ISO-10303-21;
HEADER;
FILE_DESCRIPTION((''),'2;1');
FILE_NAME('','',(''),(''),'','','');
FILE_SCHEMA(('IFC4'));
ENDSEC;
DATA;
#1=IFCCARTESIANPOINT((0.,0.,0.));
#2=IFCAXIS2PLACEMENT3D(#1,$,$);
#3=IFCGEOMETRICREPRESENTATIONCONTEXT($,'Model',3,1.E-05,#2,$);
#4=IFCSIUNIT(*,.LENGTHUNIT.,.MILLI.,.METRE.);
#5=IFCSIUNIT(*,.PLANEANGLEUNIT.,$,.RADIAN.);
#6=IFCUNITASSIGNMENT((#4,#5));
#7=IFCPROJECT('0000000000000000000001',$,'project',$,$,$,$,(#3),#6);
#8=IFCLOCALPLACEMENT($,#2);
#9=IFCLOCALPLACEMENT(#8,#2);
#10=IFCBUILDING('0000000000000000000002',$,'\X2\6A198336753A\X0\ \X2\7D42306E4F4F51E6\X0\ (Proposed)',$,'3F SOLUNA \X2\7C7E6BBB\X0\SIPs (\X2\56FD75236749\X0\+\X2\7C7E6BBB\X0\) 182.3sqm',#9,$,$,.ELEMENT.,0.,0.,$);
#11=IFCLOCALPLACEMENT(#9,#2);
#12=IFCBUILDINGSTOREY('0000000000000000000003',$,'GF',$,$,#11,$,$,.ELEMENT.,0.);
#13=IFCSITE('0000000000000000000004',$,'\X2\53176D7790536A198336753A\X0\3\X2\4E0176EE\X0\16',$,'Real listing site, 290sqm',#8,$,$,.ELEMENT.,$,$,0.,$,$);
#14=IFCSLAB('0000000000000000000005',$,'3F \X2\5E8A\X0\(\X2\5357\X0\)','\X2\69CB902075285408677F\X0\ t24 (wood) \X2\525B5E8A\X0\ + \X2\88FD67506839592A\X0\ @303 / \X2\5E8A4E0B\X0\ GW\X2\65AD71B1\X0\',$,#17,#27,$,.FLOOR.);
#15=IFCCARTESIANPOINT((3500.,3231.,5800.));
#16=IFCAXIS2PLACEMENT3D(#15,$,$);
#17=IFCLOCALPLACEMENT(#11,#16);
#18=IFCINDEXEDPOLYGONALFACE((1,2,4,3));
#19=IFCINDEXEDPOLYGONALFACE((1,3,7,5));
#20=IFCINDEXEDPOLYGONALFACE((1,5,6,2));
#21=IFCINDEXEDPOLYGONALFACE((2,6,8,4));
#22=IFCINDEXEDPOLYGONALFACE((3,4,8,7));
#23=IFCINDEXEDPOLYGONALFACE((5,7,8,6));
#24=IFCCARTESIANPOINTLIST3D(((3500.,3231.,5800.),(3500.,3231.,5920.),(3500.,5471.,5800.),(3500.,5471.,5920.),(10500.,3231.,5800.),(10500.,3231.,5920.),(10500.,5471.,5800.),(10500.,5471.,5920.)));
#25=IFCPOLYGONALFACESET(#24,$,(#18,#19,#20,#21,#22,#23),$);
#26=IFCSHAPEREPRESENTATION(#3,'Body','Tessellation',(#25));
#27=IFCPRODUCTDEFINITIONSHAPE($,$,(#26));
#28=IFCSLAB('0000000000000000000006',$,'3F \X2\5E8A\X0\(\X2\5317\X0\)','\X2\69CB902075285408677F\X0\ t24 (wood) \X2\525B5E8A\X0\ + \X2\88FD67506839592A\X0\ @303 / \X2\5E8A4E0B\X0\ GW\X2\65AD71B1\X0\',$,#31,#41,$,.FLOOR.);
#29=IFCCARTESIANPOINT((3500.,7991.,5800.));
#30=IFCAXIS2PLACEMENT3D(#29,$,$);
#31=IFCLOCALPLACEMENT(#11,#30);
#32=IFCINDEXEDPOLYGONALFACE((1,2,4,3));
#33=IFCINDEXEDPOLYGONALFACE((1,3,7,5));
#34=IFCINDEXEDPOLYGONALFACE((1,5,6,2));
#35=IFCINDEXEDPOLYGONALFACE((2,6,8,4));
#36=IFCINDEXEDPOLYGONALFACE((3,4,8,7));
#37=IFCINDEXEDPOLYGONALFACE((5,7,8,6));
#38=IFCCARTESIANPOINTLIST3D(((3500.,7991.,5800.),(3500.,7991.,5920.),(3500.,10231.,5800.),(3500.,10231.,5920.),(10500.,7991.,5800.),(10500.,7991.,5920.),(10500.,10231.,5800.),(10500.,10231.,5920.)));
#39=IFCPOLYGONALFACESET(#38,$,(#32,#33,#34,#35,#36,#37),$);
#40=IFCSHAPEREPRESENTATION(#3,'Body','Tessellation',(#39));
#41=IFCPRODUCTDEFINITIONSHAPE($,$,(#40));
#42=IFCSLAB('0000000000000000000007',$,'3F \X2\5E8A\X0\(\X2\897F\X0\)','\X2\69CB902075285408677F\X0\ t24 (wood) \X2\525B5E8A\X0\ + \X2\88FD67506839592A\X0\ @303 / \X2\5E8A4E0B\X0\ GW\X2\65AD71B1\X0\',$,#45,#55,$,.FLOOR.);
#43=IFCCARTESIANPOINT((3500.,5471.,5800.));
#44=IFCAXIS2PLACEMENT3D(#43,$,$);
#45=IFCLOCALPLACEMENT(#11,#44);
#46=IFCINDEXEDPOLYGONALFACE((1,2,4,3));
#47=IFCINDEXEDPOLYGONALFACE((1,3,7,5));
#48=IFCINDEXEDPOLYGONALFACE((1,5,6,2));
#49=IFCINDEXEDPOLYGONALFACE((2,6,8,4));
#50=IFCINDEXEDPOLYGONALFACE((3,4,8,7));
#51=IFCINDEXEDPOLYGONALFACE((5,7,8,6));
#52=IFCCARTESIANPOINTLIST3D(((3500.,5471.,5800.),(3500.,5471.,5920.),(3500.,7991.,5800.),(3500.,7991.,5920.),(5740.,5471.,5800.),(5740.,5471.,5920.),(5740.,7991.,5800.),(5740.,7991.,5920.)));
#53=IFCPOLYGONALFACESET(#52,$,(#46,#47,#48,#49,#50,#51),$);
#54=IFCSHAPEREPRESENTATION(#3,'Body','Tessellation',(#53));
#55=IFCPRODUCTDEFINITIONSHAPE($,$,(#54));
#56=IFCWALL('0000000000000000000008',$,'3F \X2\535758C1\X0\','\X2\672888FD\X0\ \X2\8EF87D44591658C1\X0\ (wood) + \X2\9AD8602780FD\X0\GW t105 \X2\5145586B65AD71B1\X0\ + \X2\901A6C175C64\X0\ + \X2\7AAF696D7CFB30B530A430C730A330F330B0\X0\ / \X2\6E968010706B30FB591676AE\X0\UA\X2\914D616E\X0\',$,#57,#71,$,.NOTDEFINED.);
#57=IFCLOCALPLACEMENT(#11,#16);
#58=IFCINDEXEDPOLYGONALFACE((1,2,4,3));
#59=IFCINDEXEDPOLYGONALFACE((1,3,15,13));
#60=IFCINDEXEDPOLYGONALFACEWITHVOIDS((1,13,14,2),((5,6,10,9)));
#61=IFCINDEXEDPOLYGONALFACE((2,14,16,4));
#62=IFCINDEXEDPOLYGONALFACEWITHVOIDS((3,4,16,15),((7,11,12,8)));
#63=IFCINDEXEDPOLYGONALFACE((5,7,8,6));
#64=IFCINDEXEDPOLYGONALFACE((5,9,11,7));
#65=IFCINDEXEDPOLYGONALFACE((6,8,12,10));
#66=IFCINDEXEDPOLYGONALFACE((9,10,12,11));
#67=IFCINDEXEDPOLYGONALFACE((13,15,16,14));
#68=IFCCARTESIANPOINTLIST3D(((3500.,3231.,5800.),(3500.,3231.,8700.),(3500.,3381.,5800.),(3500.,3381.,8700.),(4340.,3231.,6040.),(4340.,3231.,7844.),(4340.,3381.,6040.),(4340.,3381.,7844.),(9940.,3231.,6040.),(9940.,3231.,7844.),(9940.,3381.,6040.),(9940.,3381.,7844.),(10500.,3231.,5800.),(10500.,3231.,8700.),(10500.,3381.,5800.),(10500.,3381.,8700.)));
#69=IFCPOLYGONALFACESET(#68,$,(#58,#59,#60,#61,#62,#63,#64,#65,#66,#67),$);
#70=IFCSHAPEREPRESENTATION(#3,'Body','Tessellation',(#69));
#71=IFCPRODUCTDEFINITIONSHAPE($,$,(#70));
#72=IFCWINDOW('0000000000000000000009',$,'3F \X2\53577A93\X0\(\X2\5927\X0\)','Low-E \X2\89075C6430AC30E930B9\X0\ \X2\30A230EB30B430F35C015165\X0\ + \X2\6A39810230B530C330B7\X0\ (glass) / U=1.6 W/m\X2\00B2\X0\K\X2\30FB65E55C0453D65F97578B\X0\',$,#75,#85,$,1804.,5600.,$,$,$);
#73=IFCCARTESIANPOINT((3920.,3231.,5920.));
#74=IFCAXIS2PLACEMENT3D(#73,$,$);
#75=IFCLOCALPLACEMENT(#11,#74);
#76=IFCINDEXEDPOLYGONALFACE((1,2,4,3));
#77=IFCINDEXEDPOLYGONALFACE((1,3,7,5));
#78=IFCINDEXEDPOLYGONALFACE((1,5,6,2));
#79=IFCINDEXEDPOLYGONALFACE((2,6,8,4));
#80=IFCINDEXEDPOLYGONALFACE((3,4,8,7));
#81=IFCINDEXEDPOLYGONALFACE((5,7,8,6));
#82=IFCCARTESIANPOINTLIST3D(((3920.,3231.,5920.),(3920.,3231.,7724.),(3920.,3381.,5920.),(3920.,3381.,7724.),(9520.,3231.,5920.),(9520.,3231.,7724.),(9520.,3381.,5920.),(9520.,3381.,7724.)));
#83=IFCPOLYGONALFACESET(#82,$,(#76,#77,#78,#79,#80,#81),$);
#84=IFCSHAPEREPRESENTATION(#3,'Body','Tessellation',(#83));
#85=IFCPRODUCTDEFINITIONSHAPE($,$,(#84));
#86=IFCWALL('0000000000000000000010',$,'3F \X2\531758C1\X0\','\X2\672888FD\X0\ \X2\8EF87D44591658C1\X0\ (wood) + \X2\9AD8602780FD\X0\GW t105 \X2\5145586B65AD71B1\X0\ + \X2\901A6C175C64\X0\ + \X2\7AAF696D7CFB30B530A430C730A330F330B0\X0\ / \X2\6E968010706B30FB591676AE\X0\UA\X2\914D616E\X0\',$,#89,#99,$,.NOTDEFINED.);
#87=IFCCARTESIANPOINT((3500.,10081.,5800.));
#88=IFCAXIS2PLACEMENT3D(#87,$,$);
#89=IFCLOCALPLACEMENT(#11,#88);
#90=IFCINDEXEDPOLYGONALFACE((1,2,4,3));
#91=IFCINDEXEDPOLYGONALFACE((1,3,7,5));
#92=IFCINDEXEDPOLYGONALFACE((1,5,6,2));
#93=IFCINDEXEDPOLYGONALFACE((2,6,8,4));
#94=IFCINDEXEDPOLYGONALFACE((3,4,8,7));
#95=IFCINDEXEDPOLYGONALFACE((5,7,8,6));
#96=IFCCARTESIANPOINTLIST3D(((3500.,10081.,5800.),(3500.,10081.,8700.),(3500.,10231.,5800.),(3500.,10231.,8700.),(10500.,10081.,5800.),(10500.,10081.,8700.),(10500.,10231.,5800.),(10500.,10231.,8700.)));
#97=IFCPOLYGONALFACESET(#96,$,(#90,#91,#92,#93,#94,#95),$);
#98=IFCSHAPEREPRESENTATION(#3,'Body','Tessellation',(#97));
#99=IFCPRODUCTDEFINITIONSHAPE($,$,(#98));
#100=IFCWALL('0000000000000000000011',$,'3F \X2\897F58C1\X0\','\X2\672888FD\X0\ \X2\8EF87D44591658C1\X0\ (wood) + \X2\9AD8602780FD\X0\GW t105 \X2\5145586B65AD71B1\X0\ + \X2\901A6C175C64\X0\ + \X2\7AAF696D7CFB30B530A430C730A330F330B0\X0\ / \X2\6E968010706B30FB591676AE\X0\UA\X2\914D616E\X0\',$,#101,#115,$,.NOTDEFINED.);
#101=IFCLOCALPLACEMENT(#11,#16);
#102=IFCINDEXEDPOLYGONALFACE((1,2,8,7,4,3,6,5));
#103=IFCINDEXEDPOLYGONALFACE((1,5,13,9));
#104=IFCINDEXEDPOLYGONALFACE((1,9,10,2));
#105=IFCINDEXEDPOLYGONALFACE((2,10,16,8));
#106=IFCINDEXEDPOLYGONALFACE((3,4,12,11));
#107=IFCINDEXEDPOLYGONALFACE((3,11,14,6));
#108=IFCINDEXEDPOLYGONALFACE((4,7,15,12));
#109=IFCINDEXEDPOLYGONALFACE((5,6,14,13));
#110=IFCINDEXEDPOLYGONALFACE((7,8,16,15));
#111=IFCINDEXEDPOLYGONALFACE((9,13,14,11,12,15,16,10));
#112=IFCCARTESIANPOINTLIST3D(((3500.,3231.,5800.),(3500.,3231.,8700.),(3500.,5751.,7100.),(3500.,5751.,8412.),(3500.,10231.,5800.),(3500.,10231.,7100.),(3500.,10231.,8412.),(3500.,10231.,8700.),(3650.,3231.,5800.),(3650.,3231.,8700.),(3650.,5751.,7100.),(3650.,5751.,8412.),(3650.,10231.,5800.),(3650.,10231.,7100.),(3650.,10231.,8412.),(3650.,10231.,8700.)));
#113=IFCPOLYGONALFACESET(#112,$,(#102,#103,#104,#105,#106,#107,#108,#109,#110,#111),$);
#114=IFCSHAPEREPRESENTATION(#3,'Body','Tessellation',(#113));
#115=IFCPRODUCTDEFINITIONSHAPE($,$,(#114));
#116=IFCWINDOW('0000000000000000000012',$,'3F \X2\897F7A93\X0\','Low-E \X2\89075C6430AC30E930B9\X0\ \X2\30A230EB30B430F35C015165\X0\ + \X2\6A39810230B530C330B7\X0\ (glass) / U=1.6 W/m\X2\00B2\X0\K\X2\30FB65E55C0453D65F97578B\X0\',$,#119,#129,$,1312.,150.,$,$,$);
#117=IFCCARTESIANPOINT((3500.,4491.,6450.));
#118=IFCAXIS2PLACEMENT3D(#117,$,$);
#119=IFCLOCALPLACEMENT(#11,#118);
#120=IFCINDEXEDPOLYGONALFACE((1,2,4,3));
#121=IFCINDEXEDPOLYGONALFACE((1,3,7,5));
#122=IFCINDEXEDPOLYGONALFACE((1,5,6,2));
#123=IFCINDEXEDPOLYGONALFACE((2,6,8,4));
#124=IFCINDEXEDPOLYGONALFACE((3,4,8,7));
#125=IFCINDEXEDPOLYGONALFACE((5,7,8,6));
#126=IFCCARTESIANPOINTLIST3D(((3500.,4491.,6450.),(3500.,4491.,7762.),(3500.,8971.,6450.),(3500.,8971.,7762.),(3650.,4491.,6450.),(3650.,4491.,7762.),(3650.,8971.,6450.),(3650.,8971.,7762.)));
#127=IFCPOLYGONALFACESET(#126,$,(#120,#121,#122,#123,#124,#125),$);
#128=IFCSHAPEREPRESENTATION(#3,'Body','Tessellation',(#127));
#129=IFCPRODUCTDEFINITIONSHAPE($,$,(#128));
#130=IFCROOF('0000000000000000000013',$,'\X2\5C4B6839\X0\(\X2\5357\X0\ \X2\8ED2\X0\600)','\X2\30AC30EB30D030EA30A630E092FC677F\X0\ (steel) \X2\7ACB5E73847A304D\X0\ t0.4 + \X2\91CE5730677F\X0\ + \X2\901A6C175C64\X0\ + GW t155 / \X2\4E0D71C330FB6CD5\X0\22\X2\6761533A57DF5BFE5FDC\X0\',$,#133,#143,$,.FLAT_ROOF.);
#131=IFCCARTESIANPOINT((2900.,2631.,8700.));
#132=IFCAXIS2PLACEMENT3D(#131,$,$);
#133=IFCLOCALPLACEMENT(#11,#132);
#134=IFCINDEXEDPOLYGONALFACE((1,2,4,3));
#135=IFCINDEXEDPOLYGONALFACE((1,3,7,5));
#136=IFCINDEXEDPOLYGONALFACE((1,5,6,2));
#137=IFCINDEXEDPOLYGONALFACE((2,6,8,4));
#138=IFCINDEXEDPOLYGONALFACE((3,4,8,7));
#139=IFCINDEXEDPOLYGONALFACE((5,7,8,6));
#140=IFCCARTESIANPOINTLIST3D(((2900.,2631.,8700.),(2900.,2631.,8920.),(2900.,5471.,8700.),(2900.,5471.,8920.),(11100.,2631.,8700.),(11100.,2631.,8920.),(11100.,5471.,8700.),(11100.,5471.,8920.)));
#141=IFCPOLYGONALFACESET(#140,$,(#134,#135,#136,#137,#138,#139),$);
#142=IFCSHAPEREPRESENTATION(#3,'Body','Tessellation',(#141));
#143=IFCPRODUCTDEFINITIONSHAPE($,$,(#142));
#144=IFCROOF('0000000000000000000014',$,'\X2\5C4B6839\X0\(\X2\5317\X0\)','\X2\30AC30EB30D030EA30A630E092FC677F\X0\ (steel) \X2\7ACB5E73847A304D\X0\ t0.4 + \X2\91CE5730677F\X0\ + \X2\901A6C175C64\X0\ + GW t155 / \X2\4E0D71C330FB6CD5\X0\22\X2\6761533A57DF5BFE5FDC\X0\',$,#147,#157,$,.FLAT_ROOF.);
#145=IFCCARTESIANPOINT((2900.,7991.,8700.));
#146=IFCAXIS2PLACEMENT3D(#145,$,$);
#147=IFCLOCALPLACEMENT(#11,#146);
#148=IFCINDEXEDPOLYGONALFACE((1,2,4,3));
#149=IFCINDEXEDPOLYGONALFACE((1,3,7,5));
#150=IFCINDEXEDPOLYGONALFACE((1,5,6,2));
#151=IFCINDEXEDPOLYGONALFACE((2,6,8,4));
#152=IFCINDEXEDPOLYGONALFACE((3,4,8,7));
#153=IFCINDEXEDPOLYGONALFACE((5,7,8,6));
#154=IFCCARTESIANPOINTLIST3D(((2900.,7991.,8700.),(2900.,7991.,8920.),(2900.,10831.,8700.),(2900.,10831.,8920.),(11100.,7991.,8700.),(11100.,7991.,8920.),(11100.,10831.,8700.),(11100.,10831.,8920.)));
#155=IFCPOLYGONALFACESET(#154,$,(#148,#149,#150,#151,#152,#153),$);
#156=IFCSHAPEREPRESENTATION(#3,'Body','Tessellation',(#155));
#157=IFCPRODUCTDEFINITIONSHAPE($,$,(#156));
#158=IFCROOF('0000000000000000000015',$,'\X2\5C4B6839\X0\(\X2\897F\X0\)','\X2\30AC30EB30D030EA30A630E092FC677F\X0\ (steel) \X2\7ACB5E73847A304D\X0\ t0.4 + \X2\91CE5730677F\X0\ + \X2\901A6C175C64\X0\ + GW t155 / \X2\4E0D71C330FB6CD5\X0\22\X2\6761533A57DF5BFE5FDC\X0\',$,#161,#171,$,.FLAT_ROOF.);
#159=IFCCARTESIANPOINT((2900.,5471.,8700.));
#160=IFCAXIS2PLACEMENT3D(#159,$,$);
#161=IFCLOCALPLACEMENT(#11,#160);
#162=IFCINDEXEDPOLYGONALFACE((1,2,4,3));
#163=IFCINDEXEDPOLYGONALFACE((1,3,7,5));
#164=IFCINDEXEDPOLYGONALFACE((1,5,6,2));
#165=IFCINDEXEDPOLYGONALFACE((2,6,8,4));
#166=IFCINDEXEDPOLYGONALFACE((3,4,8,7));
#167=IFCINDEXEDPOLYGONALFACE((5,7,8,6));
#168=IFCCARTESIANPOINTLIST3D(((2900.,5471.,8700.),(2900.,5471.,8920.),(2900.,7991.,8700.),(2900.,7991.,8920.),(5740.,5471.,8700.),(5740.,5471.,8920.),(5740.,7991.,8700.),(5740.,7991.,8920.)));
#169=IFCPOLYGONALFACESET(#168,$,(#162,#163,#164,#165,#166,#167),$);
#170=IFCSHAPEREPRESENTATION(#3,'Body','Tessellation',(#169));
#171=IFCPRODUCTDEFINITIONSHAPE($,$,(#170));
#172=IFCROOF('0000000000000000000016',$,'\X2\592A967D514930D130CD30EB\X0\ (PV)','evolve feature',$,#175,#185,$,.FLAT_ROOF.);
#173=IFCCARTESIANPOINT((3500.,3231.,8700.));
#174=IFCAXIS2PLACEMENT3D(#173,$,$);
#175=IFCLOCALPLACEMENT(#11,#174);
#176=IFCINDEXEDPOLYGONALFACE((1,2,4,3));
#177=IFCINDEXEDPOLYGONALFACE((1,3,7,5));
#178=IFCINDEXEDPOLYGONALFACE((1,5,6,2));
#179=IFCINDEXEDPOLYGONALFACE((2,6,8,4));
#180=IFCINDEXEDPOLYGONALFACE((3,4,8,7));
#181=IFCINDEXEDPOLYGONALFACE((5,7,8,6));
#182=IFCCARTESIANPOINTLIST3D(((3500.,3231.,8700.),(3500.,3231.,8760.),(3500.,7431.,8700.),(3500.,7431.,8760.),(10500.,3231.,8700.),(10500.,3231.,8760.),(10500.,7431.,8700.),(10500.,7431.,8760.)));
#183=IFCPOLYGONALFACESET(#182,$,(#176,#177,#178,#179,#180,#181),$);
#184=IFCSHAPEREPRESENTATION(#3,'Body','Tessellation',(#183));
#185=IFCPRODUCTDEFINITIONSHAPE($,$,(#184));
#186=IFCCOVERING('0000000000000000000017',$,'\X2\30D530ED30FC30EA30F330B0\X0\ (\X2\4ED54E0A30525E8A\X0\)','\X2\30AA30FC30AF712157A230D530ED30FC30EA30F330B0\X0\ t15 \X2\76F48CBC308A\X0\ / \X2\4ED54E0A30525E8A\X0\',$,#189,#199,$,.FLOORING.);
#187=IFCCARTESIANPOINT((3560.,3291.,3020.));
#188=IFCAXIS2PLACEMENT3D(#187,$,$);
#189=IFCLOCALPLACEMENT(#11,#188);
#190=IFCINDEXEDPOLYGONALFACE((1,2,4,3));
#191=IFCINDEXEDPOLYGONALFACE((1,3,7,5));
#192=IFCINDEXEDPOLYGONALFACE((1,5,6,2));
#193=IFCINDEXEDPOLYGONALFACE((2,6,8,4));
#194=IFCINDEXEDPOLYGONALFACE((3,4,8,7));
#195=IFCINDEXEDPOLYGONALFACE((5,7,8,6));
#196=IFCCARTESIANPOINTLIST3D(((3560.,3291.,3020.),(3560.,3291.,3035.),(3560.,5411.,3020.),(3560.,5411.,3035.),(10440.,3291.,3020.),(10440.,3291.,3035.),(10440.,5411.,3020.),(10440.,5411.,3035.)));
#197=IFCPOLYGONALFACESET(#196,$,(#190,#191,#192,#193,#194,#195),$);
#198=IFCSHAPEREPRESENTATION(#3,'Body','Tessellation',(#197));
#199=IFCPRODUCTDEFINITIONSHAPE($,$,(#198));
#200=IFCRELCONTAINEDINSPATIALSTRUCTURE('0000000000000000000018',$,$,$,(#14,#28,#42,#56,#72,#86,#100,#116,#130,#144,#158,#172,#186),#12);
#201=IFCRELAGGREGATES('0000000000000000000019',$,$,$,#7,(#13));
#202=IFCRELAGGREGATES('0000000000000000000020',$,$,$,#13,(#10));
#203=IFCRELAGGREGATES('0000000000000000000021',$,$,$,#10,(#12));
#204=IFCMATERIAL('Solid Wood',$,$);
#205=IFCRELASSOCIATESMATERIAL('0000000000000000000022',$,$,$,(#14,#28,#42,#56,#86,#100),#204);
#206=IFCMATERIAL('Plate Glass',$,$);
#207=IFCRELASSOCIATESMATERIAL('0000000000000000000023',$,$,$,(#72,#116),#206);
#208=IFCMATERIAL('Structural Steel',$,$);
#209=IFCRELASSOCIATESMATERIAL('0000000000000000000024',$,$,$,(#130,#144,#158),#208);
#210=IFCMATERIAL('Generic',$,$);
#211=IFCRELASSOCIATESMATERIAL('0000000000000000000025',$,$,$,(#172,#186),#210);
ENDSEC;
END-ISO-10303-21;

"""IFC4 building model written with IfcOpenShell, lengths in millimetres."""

from ifc_helpers import new_model, si_unit, frame, frame_2d, origin, place, context, project, spatial, rectangle, extrude, material, element, fill, save


model = new_model("IFC4")

# Units and contexts
model_context = context("Model", 3, precision=1e-05, world=origin())
ifc_project = project(units=[si_unit("LENGTHUNIT", "METRE", prefix="MILLI"), si_unit("PLANEANGLEUNIT", "RADIAN")], contexts=[model_context])

# Site, building, storey
site_placement = place(None, origin())
site = spatial("IfcSite", under=ifc_project, at=site_placement, Name="北海道標茶町3丁目16", ObjectType="Real listing site, 290sqm", CompositionType="ELEMENT", RefElevation=0.0)
building_placement = place(site_placement, origin())
building = spatial("IfcBuilding", under=site, at=building_placement, Name="標茶町 終の住処 (Proposed)", ObjectType="3F SOLUNA 籾殻SIPs (国産杉+籾殻) 182.3sqm", CompositionType="ELEMENT", ElevationOfRefHeight=0.0, ElevationOfTerrain=0.0)
storey_placement = place(building_placement, origin())
storey = spatial("IfcBuildingStorey", under=building, at=storey_placement, Name="GF", CompositionType="ELEMENT", Elevation=0.0)

# Slabs
ifc_material_1 = material(Name="Solid Wood")
slab_1_placement = place(storey_placement, frame((3500.0, 3231.0, 5800.0)))
element("IfcSlab", 1, at=slab_1_placement, inside=storey, material=ifc_material_1, Name="3F 床(南)", Description="構造用合板 t24 (wood) 剛床 + 製材根太 @303 / 床下 GW断熱", PredefinedType="FLOOR", context=model_context, shape_type="SweptSolid", body=[
    extrude(rectangle(XDim=7000.0, YDim=2240.0, at=frame_2d((3500.0, 1120.0))), frame((3500.0, 3231.0, 5800.0)), (0.0, 0.0, 1.0), 120.0),
])
slab_2_placement = place(storey_placement, frame((3500.0, 7991.0, 5800.0)))
element("IfcSlab", 2, at=slab_2_placement, inside=storey, material=ifc_material_1, Name="3F 床(北)", Description="構造用合板 t24 (wood) 剛床 + 製材根太 @303 / 床下 GW断熱", PredefinedType="FLOOR", context=model_context, shape_type="SweptSolid", body=[
    extrude(rectangle(XDim=7000.0, YDim=2240.0, at=frame_2d((3500.0, 1120.0))), frame((3500.0, 7991.0, 5800.0)), (0.0, 0.0, 1.0), 120.0),
])
slab_3_placement = place(storey_placement, frame((3500.0, 5471.0, 5800.0)))
element("IfcSlab", 3, at=slab_3_placement, inside=storey, material=ifc_material_1, Name="3F 床(西)", Description="構造用合板 t24 (wood) 剛床 + 製材根太 @303 / 床下 GW断熱", PredefinedType="FLOOR", context=model_context, shape_type="SweptSolid", body=[
    extrude(rectangle(XDim=2240.0, YDim=2520.0, at=frame_2d((1120.0, 1260.0))), frame((3500.0, 5471.0, 5800.0)), (0.0, 0.0, 1.0), 120.0),
])

# Wall, opening, window
wall_1_placement = place(storey_placement, frame((3500.0, 3231.0, 5800.0)))
wall_1 = element("IfcWall", 4, at=wall_1_placement, inside=storey, material=ifc_material_1, Name="3F 南壁", Description="木製 軸組外壁 (wood) + 高性能GW t105 充填断熱 + 通気層 + 窯業系サイディング / 準耐火・外皮UA配慮", PredefinedType="NOTDEFINED", context=model_context, shape_type="SweptSolid", body=[
    extrude(rectangle(XDim=7000.0, YDim=150.0, at=frame_2d((3500.0, 75.0))), frame((3500.0, 3231.0, 5800.0)), (0.0, 0.0, 1.0), 2900.0),
])
opening_1_placement = place(storey_placement, frame((3920.0, 3231.0, 5920.0)))
opening_1 = element("IfcOpeningElement", 5, at=opening_1_placement, cuts=wall_1, PredefinedType="NOTDEFINED", context=model_context, shape_type="SweptSolid", body=[
    extrude(rectangle(XDim=5600.0, YDim=150.0, at=frame_2d((2800.0, 75.0))), frame((3920.0, 3231.0, 5920.0)), (0.0, 0.0, 1.0), 1804.0),
])
ifc_material_2 = material(Name="Plate Glass")
window_1_placement = place(storey_placement, frame((3920.0, 3231.0, 5920.0)))
window_1 = element("IfcWindow", 6, at=window_1_placement, inside=storey, material=ifc_material_2, Name="3F 南窓(大)", Description="Low-E 複層ガラス アルゴン封入 + 樹脂サッシ (glass) / U=1.6 W/m²K・日射取得型", OverallHeight=1804.0, OverallWidth=5600.0, context=model_context, shape_type="SweptSolid", body=[
    extrude(rectangle(XDim=5600.0, YDim=150.0, at=frame_2d((2800.0, 75.0))), frame((3920.0, 3231.0, 5920.0)), (0.0, 0.0, 1.0), 1804.0),
])
fill(opening_1, window_1)

# Wall
wall_2_placement = place(storey_placement, frame((3500.0, 10081.0, 5800.0)))
element("IfcWall", 7, at=wall_2_placement, inside=storey, material=ifc_material_1, Name="3F 北壁", Description="木製 軸組外壁 (wood) + 高性能GW t105 充填断熱 + 通気層 + 窯業系サイディング / 準耐火・外皮UA配慮", PredefinedType="NOTDEFINED", context=model_context, shape_type="SweptSolid", body=[
    extrude(rectangle(XDim=7000.0, YDim=150.0, at=frame_2d((3500.0, 75.0))), frame((3500.0, 10081.0, 5800.0)), (0.0, 0.0, 1.0), 2900.0),
])

# Wall, opening, window
wall_3_placement = place(storey_placement, frame((3500.0, 3231.0, 5800.0)))
wall_3 = element("IfcWall", 8, at=wall_3_placement, inside=storey, material=ifc_material_1, Name="3F 西壁", Description="木製 軸組外壁 (wood) + 高性能GW t105 充填断熱 + 通気層 + 窯業系サイディング / 準耐火・外皮UA配慮", PredefinedType="NOTDEFINED", context=model_context, shape_type="SweptSolid", body=[
    extrude(rectangle(XDim=150.0, YDim=7000.0, at=frame_2d((75.0, 3500.0))), frame((3500.0, 3231.0, 5800.0)), (0.0, 0.0, 1.0), 2900.0),
])
opening_2_placement = place(storey_placement, frame((3500.0, 4491.0, 6450.0)))
opening_2 = element("IfcOpeningElement", 9, at=opening_2_placement, cuts=wall_3, PredefinedType="NOTDEFINED", context=model_context, shape_type="SweptSolid", body=[
    extrude(rectangle(XDim=150.0, YDim=4480.0, at=frame_2d((75.0, 2240.0))), frame((3500.0, 4491.0, 6450.0)), (0.0, 0.0, 1.0), 1312.0),
])
window_2_placement = place(storey_placement, frame((3500.0, 4491.0, 6450.0)))
window_2 = element("IfcWindow", 10, at=window_2_placement, inside=storey, material=ifc_material_2, Name="3F 西窓", Description="Low-E 複層ガラス アルゴン封入 + 樹脂サッシ (glass) / U=1.6 W/m²K・日射取得型", OverallHeight=1312.0, OverallWidth=150.0, context=model_context, shape_type="SweptSolid", body=[
    extrude(rectangle(XDim=150.0, YDim=4480.0, at=frame_2d((75.0, 2240.0))), frame((3500.0, 4491.0, 6450.0)), (0.0, 0.0, 1.0), 1312.0),
])
fill(opening_2, window_2)

# Roofs
ifc_material_3 = material(Name="Structural Steel")
roof_1_placement = place(storey_placement, frame((2900.0, 2631.0, 8700.0)))
element("IfcRoof", 11, at=roof_1_placement, inside=storey, material=ifc_material_3, Name="屋根(南 軒600)", Description="ガルバリウム鋼板 (steel) 立平葺き t0.4 + 野地板 + 通気層 + GW t155 / 不燃・法22条区域対応", PredefinedType="FLAT_ROOF", context=model_context, shape_type="SweptSolid", body=[
    extrude(rectangle(XDim=8200.0, YDim=2840.0, at=frame_2d((4100.0, 1420.0))), frame((2900.0, 2631.0, 8700.0)), (0.0, 0.0, 1.0), 220.0),
])
roof_2_placement = place(storey_placement, frame((2900.0, 7991.0, 8700.0)))
element("IfcRoof", 12, at=roof_2_placement, inside=storey, material=ifc_material_3, Name="屋根(北)", Description="ガルバリウム鋼板 (steel) 立平葺き t0.4 + 野地板 + 通気層 + GW t155 / 不燃・法22条区域対応", PredefinedType="FLAT_ROOF", context=model_context, shape_type="SweptSolid", body=[
    extrude(rectangle(XDim=8200.0, YDim=2840.0, at=frame_2d((4100.0, 1420.0))), frame((2900.0, 7991.0, 8700.0)), (0.0, 0.0, 1.0), 220.0),
])
roof_3_placement = place(storey_placement, frame((2900.0, 5471.0, 8700.0)))
element("IfcRoof", 13, at=roof_3_placement, inside=storey, material=ifc_material_3, Name="屋根(西)", Description="ガルバリウム鋼板 (steel) 立平葺き t0.4 + 野地板 + 通気層 + GW t155 / 不燃・法22条区域対応", PredefinedType="FLAT_ROOF", context=model_context, shape_type="SweptSolid", body=[
    extrude(rectangle(XDim=2840.0, YDim=2520.0, at=frame_2d((1420.0, 1260.0))), frame((2900.0, 5471.0, 8700.0)), (0.0, 0.0, 1.0), 220.0),
])
ifc_material_4 = material(Name="Generic")
roof_4_placement = place(storey_placement, frame((3500.0, 3231.0, 8700.0)))
element("IfcRoof", 14, at=roof_4_placement, inside=storey, material=ifc_material_4, Name="太陽光パネル (PV)", Description="evolve feature", PredefinedType="FLAT_ROOF", context=model_context, shape_type="SweptSolid", body=[
    extrude(rectangle(XDim=7000.0, YDim=4200.0, at=frame_2d((3500.0, 2100.0))), frame((3500.0, 3231.0, 8700.0)), (0.0, 0.0, 1.0), 60.0),
])

# Covering
covering_1_placement = place(storey_placement, frame((3560.0, 3291.0, 3020.0)))
element("IfcCovering", 15, at=covering_1_placement, inside=storey, material=ifc_material_4, Name="フローリング (仕上げ床)", Description="オーク無垢フローリング t15 直貼り / 仕上げ床", PredefinedType="FLOORING", context=model_context, shape_type="SweptSolid", body=[
    extrude(rectangle(XDim=6880.0, YDim=2120.0, at=frame_2d((3440.0, 1060.0))), frame((3560.0, 3291.0, 3020.0)), (0.0, 0.0, 1.0), 15.0),
])

save(model, "model.ifc")
